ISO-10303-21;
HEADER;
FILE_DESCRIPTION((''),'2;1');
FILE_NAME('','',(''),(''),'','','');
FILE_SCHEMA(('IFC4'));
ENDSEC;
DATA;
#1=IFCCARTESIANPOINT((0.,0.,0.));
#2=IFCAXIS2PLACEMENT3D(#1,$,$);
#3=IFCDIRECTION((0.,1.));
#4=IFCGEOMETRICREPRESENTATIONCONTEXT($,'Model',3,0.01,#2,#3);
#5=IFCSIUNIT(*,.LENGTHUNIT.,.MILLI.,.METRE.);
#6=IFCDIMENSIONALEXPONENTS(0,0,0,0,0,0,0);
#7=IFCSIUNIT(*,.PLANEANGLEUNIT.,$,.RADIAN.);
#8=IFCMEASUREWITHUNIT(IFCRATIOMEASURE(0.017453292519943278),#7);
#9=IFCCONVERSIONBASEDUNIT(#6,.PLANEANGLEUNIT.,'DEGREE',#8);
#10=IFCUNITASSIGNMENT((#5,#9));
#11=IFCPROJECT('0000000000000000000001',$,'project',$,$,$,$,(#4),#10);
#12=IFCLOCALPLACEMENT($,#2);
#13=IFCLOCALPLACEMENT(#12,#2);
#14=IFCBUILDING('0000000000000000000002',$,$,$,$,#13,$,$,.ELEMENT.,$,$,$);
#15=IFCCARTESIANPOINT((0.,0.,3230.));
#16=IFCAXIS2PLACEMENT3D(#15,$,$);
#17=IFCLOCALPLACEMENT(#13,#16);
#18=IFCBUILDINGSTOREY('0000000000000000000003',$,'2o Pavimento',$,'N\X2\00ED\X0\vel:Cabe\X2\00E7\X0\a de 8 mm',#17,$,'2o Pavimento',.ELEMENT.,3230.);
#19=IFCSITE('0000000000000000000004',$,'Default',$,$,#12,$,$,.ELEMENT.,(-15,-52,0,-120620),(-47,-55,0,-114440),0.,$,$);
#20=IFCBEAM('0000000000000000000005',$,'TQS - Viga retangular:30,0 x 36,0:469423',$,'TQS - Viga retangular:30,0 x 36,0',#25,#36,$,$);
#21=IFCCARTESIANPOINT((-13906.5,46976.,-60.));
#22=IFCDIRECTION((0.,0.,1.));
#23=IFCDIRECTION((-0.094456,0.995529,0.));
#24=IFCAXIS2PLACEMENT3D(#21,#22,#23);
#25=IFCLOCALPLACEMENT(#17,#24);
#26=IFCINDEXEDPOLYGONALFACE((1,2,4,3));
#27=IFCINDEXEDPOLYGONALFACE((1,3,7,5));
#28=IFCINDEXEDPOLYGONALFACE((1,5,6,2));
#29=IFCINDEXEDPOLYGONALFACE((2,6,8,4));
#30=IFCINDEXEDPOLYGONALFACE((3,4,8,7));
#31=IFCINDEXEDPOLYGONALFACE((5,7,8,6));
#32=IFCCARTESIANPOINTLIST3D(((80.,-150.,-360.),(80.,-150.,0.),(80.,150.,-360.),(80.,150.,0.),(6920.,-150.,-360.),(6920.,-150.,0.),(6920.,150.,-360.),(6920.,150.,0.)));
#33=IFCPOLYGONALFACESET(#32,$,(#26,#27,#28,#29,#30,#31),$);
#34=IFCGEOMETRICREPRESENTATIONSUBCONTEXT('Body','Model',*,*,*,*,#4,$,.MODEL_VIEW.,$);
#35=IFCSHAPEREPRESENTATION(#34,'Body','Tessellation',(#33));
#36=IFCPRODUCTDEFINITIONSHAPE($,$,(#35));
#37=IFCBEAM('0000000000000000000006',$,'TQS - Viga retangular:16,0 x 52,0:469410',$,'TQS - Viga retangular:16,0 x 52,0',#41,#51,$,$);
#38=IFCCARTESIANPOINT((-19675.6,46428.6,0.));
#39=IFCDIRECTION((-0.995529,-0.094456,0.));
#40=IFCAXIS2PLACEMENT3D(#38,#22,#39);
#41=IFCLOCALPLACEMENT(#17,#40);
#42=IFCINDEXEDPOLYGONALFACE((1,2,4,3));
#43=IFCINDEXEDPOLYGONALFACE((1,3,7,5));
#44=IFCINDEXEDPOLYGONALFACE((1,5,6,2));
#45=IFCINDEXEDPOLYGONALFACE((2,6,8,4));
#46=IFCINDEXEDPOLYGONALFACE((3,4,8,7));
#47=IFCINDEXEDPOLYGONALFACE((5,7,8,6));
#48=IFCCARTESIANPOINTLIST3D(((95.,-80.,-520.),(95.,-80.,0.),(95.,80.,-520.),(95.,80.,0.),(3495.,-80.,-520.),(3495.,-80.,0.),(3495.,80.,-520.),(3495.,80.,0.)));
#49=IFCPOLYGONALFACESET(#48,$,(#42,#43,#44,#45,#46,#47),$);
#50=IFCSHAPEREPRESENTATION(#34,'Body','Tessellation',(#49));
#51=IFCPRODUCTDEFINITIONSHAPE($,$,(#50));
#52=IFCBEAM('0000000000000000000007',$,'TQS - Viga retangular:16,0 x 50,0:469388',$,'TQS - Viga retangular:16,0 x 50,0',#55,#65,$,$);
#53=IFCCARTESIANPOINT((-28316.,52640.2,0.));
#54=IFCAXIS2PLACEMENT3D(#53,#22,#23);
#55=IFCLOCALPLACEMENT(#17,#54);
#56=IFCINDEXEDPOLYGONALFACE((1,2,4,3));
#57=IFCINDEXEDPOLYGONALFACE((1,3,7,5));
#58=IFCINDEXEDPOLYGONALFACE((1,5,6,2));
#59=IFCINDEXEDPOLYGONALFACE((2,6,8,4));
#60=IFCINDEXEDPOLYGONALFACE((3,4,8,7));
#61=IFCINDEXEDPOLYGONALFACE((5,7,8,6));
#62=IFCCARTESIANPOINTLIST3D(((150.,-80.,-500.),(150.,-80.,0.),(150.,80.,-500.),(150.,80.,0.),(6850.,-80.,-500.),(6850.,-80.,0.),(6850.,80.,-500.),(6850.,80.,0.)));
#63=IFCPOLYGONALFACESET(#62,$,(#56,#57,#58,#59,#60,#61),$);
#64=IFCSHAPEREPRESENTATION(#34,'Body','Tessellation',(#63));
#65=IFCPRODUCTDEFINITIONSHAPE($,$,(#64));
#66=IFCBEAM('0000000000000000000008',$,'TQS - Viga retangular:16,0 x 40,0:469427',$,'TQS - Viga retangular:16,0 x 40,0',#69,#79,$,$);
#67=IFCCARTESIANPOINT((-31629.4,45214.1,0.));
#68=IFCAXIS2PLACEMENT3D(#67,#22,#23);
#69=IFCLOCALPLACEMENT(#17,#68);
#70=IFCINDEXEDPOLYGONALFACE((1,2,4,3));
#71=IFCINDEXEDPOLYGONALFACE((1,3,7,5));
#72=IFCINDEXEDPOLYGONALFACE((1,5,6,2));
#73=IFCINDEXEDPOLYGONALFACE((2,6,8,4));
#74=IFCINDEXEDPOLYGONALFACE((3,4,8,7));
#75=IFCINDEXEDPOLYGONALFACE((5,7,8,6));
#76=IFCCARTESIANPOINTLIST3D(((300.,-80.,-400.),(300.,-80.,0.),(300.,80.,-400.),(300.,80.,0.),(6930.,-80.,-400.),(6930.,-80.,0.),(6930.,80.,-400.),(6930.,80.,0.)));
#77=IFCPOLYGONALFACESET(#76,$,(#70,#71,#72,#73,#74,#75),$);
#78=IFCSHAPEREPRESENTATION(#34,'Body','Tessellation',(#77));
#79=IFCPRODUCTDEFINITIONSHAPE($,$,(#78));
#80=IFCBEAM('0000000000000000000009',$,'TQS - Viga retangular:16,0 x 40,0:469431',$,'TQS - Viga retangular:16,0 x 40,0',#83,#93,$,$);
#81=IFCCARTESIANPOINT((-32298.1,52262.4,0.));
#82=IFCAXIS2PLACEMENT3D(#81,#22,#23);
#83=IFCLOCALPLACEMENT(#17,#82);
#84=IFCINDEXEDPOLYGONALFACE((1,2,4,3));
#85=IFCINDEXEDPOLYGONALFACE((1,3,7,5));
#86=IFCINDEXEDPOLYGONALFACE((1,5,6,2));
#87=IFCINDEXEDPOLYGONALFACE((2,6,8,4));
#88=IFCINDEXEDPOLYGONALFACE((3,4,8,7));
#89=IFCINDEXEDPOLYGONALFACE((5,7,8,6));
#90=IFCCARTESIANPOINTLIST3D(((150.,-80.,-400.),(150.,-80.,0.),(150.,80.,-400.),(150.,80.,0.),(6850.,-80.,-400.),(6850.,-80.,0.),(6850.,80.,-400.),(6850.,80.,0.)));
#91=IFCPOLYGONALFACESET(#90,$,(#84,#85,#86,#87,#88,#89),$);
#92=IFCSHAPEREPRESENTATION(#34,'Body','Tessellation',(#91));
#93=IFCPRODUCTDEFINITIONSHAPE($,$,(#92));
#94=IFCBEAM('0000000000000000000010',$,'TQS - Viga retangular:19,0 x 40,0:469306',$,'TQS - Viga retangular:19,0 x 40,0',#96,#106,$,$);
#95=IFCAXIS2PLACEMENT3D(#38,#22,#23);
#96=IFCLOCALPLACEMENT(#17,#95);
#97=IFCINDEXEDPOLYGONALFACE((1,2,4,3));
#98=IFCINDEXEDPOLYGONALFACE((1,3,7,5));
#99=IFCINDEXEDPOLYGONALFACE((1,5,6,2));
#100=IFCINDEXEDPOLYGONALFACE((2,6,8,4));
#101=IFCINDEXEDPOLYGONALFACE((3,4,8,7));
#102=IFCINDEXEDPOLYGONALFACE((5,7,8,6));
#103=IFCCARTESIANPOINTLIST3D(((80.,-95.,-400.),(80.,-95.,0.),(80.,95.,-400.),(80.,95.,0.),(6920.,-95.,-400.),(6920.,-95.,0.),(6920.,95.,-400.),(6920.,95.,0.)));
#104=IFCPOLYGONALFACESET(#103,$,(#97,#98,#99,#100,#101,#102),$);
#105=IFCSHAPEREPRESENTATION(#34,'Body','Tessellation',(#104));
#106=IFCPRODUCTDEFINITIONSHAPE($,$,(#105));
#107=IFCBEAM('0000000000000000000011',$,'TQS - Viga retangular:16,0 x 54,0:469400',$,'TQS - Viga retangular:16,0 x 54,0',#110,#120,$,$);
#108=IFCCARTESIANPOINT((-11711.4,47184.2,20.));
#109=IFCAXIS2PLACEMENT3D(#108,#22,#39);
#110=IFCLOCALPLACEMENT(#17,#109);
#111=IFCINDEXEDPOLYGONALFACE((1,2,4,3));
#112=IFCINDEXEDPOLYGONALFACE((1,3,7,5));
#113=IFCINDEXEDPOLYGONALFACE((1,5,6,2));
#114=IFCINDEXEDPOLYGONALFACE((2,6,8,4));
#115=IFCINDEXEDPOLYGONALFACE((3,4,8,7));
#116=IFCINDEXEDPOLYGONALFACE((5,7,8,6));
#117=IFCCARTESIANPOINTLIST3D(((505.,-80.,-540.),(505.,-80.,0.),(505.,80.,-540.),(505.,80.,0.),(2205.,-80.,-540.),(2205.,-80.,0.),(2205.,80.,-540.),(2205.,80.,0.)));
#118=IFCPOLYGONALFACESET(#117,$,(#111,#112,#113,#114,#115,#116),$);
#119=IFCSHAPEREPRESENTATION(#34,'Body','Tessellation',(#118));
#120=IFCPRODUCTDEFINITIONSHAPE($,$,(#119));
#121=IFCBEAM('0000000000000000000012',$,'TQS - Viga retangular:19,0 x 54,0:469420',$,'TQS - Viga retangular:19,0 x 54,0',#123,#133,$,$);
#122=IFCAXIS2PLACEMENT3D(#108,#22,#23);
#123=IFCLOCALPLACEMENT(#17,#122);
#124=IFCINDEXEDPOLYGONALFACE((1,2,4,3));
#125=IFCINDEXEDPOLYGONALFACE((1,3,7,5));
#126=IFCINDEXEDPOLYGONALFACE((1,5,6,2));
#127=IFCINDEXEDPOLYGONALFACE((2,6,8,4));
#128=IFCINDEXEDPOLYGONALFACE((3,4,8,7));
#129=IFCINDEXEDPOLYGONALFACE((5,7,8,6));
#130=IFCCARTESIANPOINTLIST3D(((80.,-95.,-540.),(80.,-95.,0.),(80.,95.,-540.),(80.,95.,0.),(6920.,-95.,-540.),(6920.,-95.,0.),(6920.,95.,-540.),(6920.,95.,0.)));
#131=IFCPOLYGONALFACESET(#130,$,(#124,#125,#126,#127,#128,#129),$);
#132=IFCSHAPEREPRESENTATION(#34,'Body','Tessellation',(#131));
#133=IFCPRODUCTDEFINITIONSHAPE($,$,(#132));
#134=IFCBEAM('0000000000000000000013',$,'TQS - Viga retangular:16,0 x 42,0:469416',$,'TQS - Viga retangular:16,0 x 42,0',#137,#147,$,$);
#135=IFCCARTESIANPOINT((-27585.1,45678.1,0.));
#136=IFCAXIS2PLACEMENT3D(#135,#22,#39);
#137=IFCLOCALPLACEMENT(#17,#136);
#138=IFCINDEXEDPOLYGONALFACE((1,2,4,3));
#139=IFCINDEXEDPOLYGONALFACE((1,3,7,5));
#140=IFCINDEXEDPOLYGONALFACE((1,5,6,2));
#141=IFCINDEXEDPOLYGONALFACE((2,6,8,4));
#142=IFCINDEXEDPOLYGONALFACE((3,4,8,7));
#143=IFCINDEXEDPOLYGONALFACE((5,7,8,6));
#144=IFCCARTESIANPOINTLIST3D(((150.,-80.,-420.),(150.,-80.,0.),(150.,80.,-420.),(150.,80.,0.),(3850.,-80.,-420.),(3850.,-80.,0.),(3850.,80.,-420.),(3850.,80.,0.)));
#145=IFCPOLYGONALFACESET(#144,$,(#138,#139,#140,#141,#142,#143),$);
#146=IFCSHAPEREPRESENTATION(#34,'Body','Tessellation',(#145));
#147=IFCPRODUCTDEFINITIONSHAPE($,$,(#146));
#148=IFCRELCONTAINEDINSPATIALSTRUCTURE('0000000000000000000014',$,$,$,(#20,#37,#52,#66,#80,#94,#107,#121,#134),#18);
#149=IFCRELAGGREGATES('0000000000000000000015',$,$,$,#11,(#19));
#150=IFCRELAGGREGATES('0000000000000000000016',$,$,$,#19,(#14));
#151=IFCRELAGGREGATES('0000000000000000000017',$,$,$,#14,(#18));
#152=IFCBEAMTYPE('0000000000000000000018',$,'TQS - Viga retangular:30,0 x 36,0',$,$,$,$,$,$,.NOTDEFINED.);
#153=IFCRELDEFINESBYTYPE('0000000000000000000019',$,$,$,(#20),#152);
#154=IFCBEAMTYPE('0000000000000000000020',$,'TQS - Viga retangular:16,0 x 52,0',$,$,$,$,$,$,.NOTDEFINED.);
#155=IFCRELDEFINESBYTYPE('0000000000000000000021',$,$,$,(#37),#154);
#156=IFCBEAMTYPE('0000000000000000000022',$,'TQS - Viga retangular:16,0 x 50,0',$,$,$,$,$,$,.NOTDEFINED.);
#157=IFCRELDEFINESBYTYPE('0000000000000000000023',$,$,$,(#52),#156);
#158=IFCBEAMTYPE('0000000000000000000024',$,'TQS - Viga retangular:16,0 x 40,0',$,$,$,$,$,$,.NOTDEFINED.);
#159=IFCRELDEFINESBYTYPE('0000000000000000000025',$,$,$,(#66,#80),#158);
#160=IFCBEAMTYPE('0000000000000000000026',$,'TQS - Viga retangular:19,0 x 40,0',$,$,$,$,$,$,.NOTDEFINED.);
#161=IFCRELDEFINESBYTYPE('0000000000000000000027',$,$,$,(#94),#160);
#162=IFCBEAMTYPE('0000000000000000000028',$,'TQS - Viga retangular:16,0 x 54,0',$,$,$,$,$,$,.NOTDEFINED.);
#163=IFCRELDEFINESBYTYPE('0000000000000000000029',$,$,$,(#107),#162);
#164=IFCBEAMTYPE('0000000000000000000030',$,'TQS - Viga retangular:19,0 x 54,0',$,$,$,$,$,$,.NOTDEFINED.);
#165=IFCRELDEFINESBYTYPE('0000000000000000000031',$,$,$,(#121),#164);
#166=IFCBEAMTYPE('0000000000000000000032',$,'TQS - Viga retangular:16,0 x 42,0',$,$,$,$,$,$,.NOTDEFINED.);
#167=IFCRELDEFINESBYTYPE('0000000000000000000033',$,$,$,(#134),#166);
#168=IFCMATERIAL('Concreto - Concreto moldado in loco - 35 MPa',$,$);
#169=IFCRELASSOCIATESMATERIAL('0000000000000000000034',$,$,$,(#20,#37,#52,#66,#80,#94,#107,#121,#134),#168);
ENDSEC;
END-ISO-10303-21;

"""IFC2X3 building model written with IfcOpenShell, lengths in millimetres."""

from ifc_helpers import new_model, entity, si_unit, converted_unit, direction, frame, frame_2d, origin, origin_2d_with_axis, place, context, subcontext, project, spatial, rectangle, extrude, material, type_object, element, save


model = new_model("IFC2X3")

# Units and contexts
model_context = context("Model", 3, precision=0.01, world=origin(), true_north=direction((0.0, 1.0)))
body_context = subcontext(model_context, "Body", "Model", "MODEL_VIEW")
ifc_project = project(units=[si_unit("LENGTHUNIT", "METRE", prefix="MILLI"), converted_unit("PLANEANGLEUNIT", "DEGREE", entity("IfcRatioMeasure", 0.017453292519943278), si_unit("PLANEANGLEUNIT", "RADIAN"), dimensions=[0, 0, 0, 0, 0, 0, 0])], contexts=[model_context])

# Site, building, storey
site_placement = place(None, origin())
site = spatial("IfcSite", under=ifc_project, at=site_placement, Name="Default", CompositionType="ELEMENT", RefLatitude=(-15, -52, 0, -120620), RefLongitude=(-47, -55, 0, -114440), RefElevation=0.0)
building_placement = place(site_placement, origin())
building = spatial("IfcBuilding", under=site, at=building_placement, CompositionType="ELEMENT")
storey_placement = place(building_placement, frame((0.0, 0.0, 3230.0)))
storey = spatial("IfcBuildingStorey", under=building, at=storey_placement, Name="2o Pavimento", ObjectType="Nível:Cabeça de 8 mm", LongName="2o Pavimento", CompositionType="ELEMENT", Elevation=3230.0)

# Beams
ifc_material = material(Name="Concreto - Concreto moldado in loco - 35 MPa")
beam_type_1 = type_object("IfcBeamType", Name="TQS - Viga retangular:30,0 x 36,0", PredefinedType="NOTDEFINED")
beam_1_placement = place(storey_placement, frame((-13906.5, 46976.0, -60.0), z_axis=(0.0, 0.0, 1.0), x_axis=(-0.094456, 0.995529, 0.0)))
element("IfcBeam", 1, at=beam_1_placement, inside=storey, type_object=beam_type_1, material=ifc_material, Name="TQS - Viga retangular:30,0 x 36,0:469423", ObjectType="TQS - Viga retangular:30,0 x 36,0", context=body_context, shape_type="SweptSolid", body=[
    extrude(rectangle(XDim=360.0, YDim=300.0, at=frame_2d((0.0, 0.0), x_axis=(1.0, 0.0))), frame((80.0, 0.0, -180.0), z_axis=(1.0, 0.0, 0.0), x_axis=(0.0, 0.0, -1.0)), (0.0, 0.0, 1.0), 6840.0),
])
beam_type_2 = type_object("IfcBeamType", Name="TQS - Viga retangular:16,0 x 52,0", PredefinedType="NOTDEFINED")
beam_2_placement = place(storey_placement, frame((-19675.6, 46428.6, 0.0), z_axis=(0.0, 0.0, 1.0), x_axis=(-0.995529, -0.094456, 0.0)))
element("IfcBeam", 2, at=beam_2_placement, inside=storey, type_object=beam_type_2, material=ifc_material, Name="TQS - Viga retangular:16,0 x 52,0:469410", ObjectType="TQS - Viga retangular:16,0 x 52,0", context=body_context, shape_type="SweptSolid", body=[
    extrude(rectangle(XDim=520.0, YDim=160.0, at=frame_2d((0.0, 0.0), x_axis=(1.0, 0.0))), frame((95.0, 0.0, -260.0), z_axis=(1.0, 0.0, 0.0), x_axis=(0.0, 0.0, -1.0)), (0.0, 0.0, 1.0), 3400.0),
])
beam_type_3 = type_object("IfcBeamType", Name="TQS - Viga retangular:16,0 x 50,0", PredefinedType="NOTDEFINED")
beam_3_placement = place(storey_placement, frame((-28316.0, 52640.2, 0.0), z_axis=(0.0, 0.0, 1.0), x_axis=(-0.094456, 0.995529, 0.0)))
element("IfcBeam", 3, at=beam_3_placement, inside=storey, type_object=beam_type_3, material=ifc_material, Name="TQS - Viga retangular:16,0 x 50,0:469388", ObjectType="TQS - Viga retangular:16,0 x 50,0", context=body_context, shape_type="SweptSolid", body=[
    extrude(rectangle(XDim=500.0, YDim=160.0, at=frame_2d((0.0, 0.0), x_axis=(1.0, 0.0))), frame((150.0, 0.0, -250.0), z_axis=(1.0, 0.0, 0.0), x_axis=(0.0, 0.0, -1.0)), (0.0, 0.0, 1.0), 6700.0),
])
beam_type_4 = type_object("IfcBeamType", Name="TQS - Viga retangular:16,0 x 40,0", PredefinedType="NOTDEFINED")
beam_4_placement = place(storey_placement, frame((-31629.4, 45214.1, 0.0), z_axis=(0.0, 0.0, 1.0), x_axis=(-0.094456, 0.995529, 0.0)))
element("IfcBeam", 4, at=beam_4_placement, inside=storey, type_object=beam_type_4, material=ifc_material, Name="TQS - Viga retangular:16,0 x 40,0:469427", ObjectType="TQS - Viga retangular:16,0 x 40,0", context=body_context, shape_type="SweptSolid", body=[
    extrude(rectangle(XDim=400.0, YDim=160.0, at=frame_2d((0.0, 0.0), x_axis=(1.0, 0.0))), frame((300.0, 0.0, -200.0), z_axis=(1.0, 0.0, 0.0), x_axis=(0.0, 0.0, -1.0)), (0.0, 0.0, 1.0), 6630.0),
])
beam_5_placement = place(storey_placement, frame((-32298.1, 52262.4, 0.0), z_axis=(0.0, 0.0, 1.0), x_axis=(-0.094456, 0.995529, 0.0)))
element("IfcBeam", 5, at=beam_5_placement, inside=storey, type_object=beam_type_4, material=ifc_material, Name="TQS - Viga retangular:16,0 x 40,0:469431", ObjectType="TQS - Viga retangular:16,0 x 40,0", context=body_context, shape_type="SweptSolid", body=[
    extrude(rectangle(XDim=400.0, YDim=160.0, at=frame_2d((0.0, 0.0), x_axis=(1.0, 0.0))), frame((150.0, 0.0, -200.0), z_axis=(1.0, 0.0, 0.0), x_axis=(0.0, 0.0, -1.0)), (0.0, 0.0, 1.0), 6700.0),
])
beam_type_5 = type_object("IfcBeamType", Name="TQS - Viga retangular:19,0 x 40,0", PredefinedType="NOTDEFINED")
beam_6_placement = place(storey_placement, frame((-19675.6, 46428.6, 0.0), z_axis=(0.0, 0.0, 1.0), x_axis=(-0.094456, 0.995529, 0.0)))
element("IfcBeam", 6, at=beam_6_placement, inside=storey, type_object=beam_type_5, material=ifc_material, Name="TQS - Viga retangular:19,0 x 40,0:469306", ObjectType="TQS - Viga retangular:19,0 x 40,0", context=body_context, shape_type="SweptSolid", body=[
    extrude(rectangle(XDim=400.0, YDim=190.0, at=frame_2d((0.0, 0.0), x_axis=(1.0, 0.0))), frame((80.0, 0.0, -200.0), z_axis=(1.0, 0.0, 0.0), x_axis=(0.0, 0.0, -1.0)), (0.0, 0.0, 1.0), 6840.0),
])
beam_type_6 = type_object("IfcBeamType", Name="TQS - Viga retangular:16,0 x 54,0", PredefinedType="NOTDEFINED")
beam_7_placement = place(storey_placement, frame((-11711.4, 47184.2, 20.0), z_axis=(0.0, 0.0, 1.0), x_axis=(-0.995529, -0.094456, 0.0)))
element("IfcBeam", 7, at=beam_7_placement, inside=storey, type_object=beam_type_6, material=ifc_material, Name="TQS - Viga retangular:16,0 x 54,0:469400", ObjectType="TQS - Viga retangular:16,0 x 54,0", context=body_context, shape_type="SweptSolid", body=[
    extrude(rectangle(XDim=540.0, YDim=160.0, at=frame_2d((0.0, 0.0), x_axis=(1.0, 0.0))), frame((505.0, 0.0, -270.0), z_axis=(1.0, 0.0, 0.0), x_axis=(0.0, 0.0, -1.0)), (0.0, 0.0, 1.0), 1700.0),
])
beam_type_7 = type_object("IfcBeamType", Name="TQS - Viga retangular:19,0 x 54,0", PredefinedType="NOTDEFINED")
beam_8_placement = place(storey_placement, frame((-11711.4, 47184.2, 20.0), z_axis=(0.0, 0.0, 1.0), x_axis=(-0.094456, 0.995529, 0.0)))
element("IfcBeam", 8, at=beam_8_placement, inside=storey, type_object=beam_type_7, material=ifc_material, Name="TQS - Viga retangular:19,0 x 54,0:469420", ObjectType="TQS - Viga retangular:19,0 x 54,0", context=body_context, shape_type="SweptSolid", body=[
    extrude(rectangle(XDim=540.0, YDim=190.0, at=origin_2d_with_axis()), frame((80.0, 0.0, -270.0), z_axis=(1.0, 0.0, 0.0), x_axis=(0.0, 0.0, -1.0)), (0.0, 0.0, 1.0), 6840.0),
])
beam_type_8 = type_object("IfcBeamType", Name="TQS - Viga retangular:16,0 x 42,0", PredefinedType="NOTDEFINED")
beam_9_placement = place(storey_placement, frame((-27585.1, 45678.1, 0.0), z_axis=(0.0, 0.0, 1.0), x_axis=(-0.995529, -0.094456, 0.0)))
element("IfcBeam", 9, at=beam_9_placement, inside=storey, type_object=beam_type_8, material=ifc_material, Name="TQS - Viga retangular:16,0 x 42,0:469416", ObjectType="TQS - Viga retangular:16,0 x 42,0", context=body_context, shape_type="SweptSolid", body=[
    extrude(rectangle(XDim=420.0, YDim=160.0, at=frame_2d((0.0, 0.0), x_axis=(1.0, 0.0))), frame((150.0, 0.0, -210.0), z_axis=(1.0, 0.0, 0.0), x_axis=(0.0, 0.0, -1.0)), (0.0, 0.0, 1.0), 3700.0),
])

save(model, "model.ifc")
